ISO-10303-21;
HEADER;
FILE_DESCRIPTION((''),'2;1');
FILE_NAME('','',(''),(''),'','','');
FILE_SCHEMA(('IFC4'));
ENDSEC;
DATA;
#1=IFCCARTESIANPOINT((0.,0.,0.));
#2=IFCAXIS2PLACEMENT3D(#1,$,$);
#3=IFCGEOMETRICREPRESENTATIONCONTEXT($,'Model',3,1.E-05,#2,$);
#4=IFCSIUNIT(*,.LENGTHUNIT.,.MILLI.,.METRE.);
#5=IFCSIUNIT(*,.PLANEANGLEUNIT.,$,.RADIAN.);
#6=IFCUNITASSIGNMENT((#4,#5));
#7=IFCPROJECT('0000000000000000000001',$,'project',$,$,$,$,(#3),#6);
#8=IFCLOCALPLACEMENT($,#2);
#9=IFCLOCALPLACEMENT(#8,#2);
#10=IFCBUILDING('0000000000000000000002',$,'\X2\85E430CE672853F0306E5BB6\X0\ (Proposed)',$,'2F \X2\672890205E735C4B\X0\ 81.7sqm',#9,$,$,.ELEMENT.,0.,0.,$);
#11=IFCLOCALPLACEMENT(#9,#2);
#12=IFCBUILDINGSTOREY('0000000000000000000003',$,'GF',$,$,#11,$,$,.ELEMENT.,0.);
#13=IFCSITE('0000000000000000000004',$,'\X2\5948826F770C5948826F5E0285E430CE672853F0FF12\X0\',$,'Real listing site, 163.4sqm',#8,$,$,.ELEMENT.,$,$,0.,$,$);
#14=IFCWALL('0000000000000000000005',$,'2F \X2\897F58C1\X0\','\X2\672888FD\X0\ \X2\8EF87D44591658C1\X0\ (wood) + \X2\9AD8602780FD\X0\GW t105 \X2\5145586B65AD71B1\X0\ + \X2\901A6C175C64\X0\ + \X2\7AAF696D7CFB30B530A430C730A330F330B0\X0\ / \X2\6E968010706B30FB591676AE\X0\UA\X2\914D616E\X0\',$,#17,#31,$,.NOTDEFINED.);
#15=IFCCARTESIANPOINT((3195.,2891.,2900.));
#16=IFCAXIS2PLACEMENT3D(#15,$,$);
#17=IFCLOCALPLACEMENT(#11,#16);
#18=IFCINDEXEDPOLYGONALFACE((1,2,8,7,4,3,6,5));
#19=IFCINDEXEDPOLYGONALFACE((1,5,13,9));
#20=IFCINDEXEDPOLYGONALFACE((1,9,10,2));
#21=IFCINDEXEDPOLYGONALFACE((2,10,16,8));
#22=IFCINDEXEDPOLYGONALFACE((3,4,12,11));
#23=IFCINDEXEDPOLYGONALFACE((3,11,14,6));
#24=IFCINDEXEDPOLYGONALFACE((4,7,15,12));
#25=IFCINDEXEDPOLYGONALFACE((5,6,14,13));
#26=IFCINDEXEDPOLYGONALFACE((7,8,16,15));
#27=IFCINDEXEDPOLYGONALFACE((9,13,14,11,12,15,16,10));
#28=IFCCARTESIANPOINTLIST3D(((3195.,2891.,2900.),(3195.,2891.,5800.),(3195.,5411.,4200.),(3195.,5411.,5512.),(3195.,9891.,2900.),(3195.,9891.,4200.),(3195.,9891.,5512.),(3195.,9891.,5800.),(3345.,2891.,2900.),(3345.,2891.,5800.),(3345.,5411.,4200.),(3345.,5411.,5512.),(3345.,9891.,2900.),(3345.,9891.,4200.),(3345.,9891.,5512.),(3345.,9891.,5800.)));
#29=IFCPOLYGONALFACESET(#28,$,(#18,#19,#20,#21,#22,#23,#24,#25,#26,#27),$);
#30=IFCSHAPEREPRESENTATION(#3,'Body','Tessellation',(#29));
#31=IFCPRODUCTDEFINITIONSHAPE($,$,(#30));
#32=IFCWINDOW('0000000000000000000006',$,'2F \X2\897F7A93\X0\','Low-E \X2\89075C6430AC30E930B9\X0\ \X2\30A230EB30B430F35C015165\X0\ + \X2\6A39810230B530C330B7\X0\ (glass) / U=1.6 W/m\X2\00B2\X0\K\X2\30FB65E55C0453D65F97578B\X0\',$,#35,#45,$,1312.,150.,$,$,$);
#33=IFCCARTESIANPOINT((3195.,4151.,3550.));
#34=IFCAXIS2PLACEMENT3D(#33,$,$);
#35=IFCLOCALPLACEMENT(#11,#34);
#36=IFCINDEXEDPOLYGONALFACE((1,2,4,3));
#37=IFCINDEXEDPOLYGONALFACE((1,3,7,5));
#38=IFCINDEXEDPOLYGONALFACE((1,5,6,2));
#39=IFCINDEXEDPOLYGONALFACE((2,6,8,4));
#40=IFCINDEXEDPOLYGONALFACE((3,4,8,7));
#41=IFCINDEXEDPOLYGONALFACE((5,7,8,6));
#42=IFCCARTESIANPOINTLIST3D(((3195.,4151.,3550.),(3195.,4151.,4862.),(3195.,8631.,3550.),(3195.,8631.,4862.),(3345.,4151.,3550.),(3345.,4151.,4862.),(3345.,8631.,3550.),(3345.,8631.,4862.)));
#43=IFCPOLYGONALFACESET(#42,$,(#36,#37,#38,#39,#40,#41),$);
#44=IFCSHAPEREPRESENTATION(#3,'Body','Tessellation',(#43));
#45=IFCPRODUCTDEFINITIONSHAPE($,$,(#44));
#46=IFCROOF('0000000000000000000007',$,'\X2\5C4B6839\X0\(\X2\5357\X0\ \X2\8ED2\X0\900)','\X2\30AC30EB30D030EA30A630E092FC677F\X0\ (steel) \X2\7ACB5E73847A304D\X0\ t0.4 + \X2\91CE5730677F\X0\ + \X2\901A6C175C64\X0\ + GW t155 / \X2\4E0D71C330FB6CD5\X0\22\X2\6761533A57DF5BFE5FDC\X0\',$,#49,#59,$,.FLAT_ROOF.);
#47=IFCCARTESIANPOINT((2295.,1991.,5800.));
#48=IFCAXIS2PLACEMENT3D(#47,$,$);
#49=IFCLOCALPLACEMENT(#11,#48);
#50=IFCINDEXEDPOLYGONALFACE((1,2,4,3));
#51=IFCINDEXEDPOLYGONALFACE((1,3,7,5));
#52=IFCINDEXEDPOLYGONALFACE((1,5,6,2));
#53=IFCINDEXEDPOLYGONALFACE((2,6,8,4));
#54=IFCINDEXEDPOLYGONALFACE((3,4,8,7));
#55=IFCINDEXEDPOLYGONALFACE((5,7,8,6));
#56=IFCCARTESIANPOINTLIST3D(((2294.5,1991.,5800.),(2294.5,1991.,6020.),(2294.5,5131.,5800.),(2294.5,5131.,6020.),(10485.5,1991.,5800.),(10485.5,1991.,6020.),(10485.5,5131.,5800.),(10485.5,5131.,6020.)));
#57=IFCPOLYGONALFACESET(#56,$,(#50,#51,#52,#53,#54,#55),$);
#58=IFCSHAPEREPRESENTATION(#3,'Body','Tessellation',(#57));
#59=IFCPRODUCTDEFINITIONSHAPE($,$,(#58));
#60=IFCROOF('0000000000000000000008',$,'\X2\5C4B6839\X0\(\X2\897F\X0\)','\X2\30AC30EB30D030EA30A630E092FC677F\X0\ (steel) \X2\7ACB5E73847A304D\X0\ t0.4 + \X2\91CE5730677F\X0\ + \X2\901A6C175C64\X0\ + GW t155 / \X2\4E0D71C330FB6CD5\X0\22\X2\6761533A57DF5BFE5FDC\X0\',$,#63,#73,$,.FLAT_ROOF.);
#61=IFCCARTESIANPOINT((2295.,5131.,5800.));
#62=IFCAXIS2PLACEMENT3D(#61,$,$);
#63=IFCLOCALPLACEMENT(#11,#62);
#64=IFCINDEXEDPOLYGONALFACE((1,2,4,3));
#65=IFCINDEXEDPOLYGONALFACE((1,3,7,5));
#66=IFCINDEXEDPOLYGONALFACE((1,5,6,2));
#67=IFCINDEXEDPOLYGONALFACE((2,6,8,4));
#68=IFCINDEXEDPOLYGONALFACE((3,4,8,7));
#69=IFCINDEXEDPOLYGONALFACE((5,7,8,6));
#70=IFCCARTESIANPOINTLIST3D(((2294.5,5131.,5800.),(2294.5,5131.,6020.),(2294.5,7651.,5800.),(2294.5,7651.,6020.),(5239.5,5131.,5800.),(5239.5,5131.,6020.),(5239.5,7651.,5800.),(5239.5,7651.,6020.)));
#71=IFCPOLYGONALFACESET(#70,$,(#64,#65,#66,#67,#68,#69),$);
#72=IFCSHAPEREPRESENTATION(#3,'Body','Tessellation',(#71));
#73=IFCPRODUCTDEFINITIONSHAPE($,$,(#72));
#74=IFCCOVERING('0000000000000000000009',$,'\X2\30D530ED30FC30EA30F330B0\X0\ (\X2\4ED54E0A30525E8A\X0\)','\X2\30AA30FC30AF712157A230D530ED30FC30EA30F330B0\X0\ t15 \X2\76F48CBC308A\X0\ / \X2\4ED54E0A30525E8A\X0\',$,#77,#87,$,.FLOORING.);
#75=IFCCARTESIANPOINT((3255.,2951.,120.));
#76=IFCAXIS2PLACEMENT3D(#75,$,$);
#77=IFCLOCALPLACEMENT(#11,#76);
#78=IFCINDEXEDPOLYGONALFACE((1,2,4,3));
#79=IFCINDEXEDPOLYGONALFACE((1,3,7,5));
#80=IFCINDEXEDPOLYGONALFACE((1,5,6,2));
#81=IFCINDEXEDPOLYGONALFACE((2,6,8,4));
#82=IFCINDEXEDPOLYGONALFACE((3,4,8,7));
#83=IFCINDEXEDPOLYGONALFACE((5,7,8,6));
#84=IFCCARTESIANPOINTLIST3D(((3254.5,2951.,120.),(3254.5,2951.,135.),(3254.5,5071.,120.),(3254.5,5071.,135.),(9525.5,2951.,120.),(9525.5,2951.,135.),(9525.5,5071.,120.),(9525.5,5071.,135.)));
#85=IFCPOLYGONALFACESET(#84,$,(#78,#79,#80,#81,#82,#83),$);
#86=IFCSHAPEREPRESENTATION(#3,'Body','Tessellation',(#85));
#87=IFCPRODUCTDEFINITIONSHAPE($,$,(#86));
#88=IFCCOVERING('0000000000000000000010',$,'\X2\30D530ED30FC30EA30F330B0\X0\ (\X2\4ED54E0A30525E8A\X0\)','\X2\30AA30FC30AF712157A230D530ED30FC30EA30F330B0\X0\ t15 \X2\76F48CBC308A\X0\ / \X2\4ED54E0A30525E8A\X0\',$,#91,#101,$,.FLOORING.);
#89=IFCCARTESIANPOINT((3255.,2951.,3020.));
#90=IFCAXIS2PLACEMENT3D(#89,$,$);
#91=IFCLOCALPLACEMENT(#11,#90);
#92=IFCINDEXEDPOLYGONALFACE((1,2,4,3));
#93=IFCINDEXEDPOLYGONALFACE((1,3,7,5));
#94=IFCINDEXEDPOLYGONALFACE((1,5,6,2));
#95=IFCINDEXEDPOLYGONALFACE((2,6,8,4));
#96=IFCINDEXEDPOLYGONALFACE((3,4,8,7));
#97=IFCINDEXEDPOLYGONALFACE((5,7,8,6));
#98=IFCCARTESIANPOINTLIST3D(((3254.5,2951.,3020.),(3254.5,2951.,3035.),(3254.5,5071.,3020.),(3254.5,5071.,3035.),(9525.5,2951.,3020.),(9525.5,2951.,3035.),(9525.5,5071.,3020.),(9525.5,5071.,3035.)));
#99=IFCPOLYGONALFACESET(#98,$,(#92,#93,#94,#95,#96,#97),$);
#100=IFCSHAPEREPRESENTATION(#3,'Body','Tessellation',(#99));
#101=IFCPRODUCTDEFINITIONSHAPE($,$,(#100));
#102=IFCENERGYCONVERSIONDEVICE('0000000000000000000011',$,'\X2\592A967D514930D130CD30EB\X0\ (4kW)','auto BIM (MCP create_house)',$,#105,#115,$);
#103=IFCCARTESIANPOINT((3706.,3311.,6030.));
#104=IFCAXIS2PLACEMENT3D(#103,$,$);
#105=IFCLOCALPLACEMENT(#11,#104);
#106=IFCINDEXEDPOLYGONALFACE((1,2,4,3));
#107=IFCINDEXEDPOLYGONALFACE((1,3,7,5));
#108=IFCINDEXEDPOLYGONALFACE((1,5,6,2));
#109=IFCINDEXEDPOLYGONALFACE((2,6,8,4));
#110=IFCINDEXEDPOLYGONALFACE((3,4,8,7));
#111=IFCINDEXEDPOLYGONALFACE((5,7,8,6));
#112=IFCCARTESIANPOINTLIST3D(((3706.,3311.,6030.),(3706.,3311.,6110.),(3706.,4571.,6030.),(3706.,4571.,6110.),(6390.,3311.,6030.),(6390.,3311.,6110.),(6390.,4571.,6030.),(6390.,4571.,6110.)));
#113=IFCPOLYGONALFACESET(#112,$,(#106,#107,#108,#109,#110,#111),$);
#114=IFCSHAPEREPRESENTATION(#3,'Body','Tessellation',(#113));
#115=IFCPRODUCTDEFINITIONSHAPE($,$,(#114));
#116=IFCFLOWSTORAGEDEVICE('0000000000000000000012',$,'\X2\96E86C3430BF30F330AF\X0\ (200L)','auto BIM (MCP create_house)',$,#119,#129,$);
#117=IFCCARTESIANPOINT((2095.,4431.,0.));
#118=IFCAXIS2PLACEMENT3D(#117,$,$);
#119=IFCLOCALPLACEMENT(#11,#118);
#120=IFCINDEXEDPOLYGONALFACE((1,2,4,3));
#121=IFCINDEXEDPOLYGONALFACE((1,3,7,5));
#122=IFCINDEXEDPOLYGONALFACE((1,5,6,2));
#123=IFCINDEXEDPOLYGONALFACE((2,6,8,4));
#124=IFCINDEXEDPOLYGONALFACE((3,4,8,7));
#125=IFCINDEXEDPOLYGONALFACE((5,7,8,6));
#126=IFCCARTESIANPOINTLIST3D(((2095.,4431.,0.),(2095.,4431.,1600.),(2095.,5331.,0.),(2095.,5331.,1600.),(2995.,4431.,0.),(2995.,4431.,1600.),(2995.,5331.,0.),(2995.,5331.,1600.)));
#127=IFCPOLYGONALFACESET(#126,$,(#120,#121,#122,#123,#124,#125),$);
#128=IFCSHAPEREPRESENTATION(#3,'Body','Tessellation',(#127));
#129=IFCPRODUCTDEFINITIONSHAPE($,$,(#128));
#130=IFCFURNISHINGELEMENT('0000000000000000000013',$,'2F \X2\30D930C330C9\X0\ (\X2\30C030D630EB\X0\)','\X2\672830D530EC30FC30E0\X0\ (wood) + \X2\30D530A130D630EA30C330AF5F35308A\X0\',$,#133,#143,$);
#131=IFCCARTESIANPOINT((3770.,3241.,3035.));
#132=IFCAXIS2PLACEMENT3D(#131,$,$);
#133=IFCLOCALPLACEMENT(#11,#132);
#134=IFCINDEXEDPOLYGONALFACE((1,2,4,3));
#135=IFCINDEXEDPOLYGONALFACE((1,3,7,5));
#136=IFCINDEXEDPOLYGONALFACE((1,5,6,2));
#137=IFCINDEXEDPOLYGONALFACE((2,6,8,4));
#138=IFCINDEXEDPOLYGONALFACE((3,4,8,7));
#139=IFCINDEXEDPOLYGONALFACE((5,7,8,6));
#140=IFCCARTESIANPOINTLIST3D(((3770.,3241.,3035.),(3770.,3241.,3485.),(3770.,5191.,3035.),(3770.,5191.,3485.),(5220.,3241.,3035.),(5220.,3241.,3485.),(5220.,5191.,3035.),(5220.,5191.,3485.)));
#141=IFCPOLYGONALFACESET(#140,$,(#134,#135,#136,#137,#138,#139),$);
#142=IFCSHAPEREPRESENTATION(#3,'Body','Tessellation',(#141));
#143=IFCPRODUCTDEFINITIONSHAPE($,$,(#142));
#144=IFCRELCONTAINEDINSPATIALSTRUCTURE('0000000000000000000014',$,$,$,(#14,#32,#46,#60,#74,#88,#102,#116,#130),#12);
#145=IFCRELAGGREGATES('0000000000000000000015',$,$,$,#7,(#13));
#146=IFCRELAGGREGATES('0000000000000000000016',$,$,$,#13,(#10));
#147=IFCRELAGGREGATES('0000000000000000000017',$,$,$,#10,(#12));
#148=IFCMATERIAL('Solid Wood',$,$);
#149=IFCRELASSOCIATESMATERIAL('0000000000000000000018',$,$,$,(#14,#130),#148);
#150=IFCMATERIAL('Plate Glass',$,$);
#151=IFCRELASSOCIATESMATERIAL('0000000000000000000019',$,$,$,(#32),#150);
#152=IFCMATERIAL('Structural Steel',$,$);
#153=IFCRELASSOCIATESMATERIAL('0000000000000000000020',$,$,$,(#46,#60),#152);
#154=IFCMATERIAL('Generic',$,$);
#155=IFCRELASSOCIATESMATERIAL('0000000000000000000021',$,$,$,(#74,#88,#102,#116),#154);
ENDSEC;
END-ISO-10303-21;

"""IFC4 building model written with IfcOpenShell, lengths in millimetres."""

from ifc_helpers import new_model, si_unit, frame, frame_2d, origin, place, context, project, spatial, rectangle, extrude, material, element, fill, save


model = new_model("IFC4")

# Units and contexts
model_context = context("Model", 3, precision=1e-05, world=origin())
ifc_project = project(units=[si_unit("LENGTHUNIT", "METRE", prefix="MILLI"), si_unit("PLANEANGLEUNIT", "RADIAN")], contexts=[model_context])

# Site, building, storey
site_placement = place(None, origin())
site = spatial("IfcSite", under=ifc_project, at=site_placement, Name="奈良県奈良市藤ノ木台２", ObjectType="Real listing site, 163.4sqm", CompositionType="ELEMENT", RefElevation=0.0)
building_placement = place(site_placement, origin())
building = spatial("IfcBuilding", under=site, at=building_placement, Name="藤ノ木台の家 (Proposed)", ObjectType="2F 木造平屋 81.7sqm", CompositionType="ELEMENT", ElevationOfRefHeight=0.0, ElevationOfTerrain=0.0)
storey_placement = place(building_placement, origin())
storey = spatial("IfcBuildingStorey", under=building, at=storey_placement, Name="GF", CompositionType="ELEMENT", Elevation=0.0)

# Shared definitions
ifc_material_1 = material(Name="Solid Wood")

# Shared definitions
ifc_material_2 = material(Name="Plate Glass")

# Wall, opening, window
wall_1_placement = place(storey_placement, frame((3195.0, 2891.0, 2900.0)))
wall_1 = element("IfcWall", 1, at=wall_1_placement, inside=storey, material=ifc_material_1, Name="2F 西壁", Description="木製 軸組外壁 (wood) + 高性能GW t105 充填断熱 + 通気層 + 窯業系サイディング / 準耐火・外皮UA配慮", PredefinedType="NOTDEFINED", context=model_context, shape_type="SweptSolid", body=[
    extrude(rectangle(XDim=150.0, YDim=7000.0, at=frame_2d((75.0, 3500.0))), frame((3195.0, 2891.0, 2900.0)), (0.0, 0.0, 1.0), 2900.0),
])
opening_1_placement = place(storey_placement, frame((3195.0, 4151.0, 3550.0)))
opening_1 = element("IfcOpeningElement", 2, at=opening_1_placement, cuts=wall_1, PredefinedType="NOTDEFINED", context=model_context, shape_type="SweptSolid", body=[
    extrude(rectangle(XDim=150.0, YDim=4480.0, at=frame_2d((75.0, 2240.0))), frame((3195.0, 4151.0, 3550.0)), (0.0, 0.0, 1.0), 1312.0),
])
window_1_placement = place(storey_placement, frame((3195.0, 4151.0, 3550.0)))
window_1 = element("IfcWindow", 3, at=window_1_placement, inside=storey, material=ifc_material_2, Name="2F 西窓", Description="Low-E 複層ガラス アルゴン封入 + 樹脂サッシ (glass) / U=1.6 W/m²K・日射取得型", OverallHeight=1312.0, OverallWidth=150.0, context=model_context, shape_type="SweptSolid", body=[
    extrude(rectangle(XDim=150.0, YDim=4480.0, at=frame_2d((75.0, 2240.0))), frame((3195.0, 4151.0, 3550.0)), (0.0, 0.0, 1.0), 1312.0),
])
fill(opening_1, window_1)

# Roofs
ifc_material_3 = material(Name="Structural Steel")
roof_1_placement = place(storey_placement, frame((2295.0, 1991.0, 5800.0)))
element("IfcRoof", 4, at=roof_1_placement, inside=storey, material=ifc_material_3, Name="屋根(南 軒900)", Description="ガルバリウム鋼板 (steel) 立平葺き t0.4 + 野地板 + 通気層 + GW t155 / 不燃・法22条区域対応", PredefinedType="FLAT_ROOF", context=model_context, shape_type="SweptSolid", body=[
    extrude(rectangle(XDim=8191.0, YDim=3140.0, at=frame_2d((4095.0, 1570.0))), frame((2295.0, 1991.0, 5800.0)), (0.0, 0.0, 1.0), 220.0),
])
roof_2_placement = place(storey_placement, frame((2295.0, 5131.0, 5800.0)))
element("IfcRoof", 5, at=roof_2_placement, inside=storey, material=ifc_material_3, Name="屋根(西)", Description="ガルバリウム鋼板 (steel) 立平葺き t0.4 + 野地板 + 通気層 + GW t155 / 不燃・法22条区域対応", PredefinedType="FLAT_ROOF", context=model_context, shape_type="SweptSolid", body=[
    extrude(rectangle(XDim=2945.0, YDim=2520.0, at=frame_2d((1472.0, 1260.0))), frame((2295.0, 5131.0, 5800.0)), (0.0, 0.0, 1.0), 220.0),
])

# Coverings
ifc_material_4 = material(Name="Generic")
covering_1_placement = place(storey_placement, frame((3255.0, 2951.0, 120.0)))
element("IfcCovering", 6, at=covering_1_placement, inside=storey, material=ifc_material_4, Name="フローリング (仕上げ床)", Description="オーク無垢フローリング t15 直貼り / 仕上げ床", PredefinedType="FLOORING", context=model_context, shape_type="SweptSolid", body=[
    extrude(rectangle(XDim=6271.0, YDim=2120.0, at=frame_2d((3135.0, 1060.0))), frame((3255.0, 2951.0, 120.0)), (0.0, 0.0, 1.0), 15.0),
])
covering_2_placement = place(storey_placement, frame((3255.0, 2951.0, 3020.0)))
element("IfcCovering", 7, at=covering_2_placement, inside=storey, material=ifc_material_4, Name="フローリング (仕上げ床)", Description="オーク無垢フローリング t15 直貼り / 仕上げ床", PredefinedType="FLOORING", context=model_context, shape_type="SweptSolid", body=[
    extrude(rectangle(XDim=6271.0, YDim=2120.0, at=frame_2d((3135.0, 1060.0))), frame((3255.0, 2951.0, 3020.0)), (0.0, 0.0, 1.0), 15.0),
])

# Energy conversion device
energy_conversion_device_placement = place(storey_placement, frame((3706.0, 3311.0, 6030.0)))
element("IfcEnergyConversionDevice", 8, at=energy_conversion_device_placement, inside=storey, material=ifc_material_4, Name="太陽光パネル (4kW)", Description="auto BIM (MCP create_house)", context=model_context, shape_type="SweptSolid", body=[
    extrude(rectangle(XDim=2684.0, YDim=1260.0, at=frame_2d((1342.0, 630.0))), frame((3706.0, 3311.0, 6030.0)), (0.0, 0.0, 1.0), 80.0),
])

# Flow storage device
flow_storage_device_placement = place(storey_placement, frame((2095.0, 4431.0, 0.0)))
element("IfcFlowStorageDevice", 9, at=flow_storage_device_placement, inside=storey, material=ifc_material_4, Name="雨水タンク (200L)", Description="auto BIM (MCP create_house)", context=model_context, shape_type="SweptSolid", body=[
    extrude(rectangle(XDim=900.0, YDim=900.0, at=frame_2d((450.0, 450.0))), frame((2095.0, 4431.0, 0.0)), (0.0, 0.0, 1.0), 1600.0),
])

# Furnishing element
furnishing_placement = place(storey_placement, frame((3770.0, 3241.0, 3035.0)))
element("IfcFurnishingElement", 10, at=furnishing_placement, inside=storey, material=ifc_material_1, Name="2F ベッド (ダブル)", Description="木フレーム (wood) + ファブリック張り", context=model_context, shape_type="SweptSolid", body=[
    extrude(rectangle(XDim=1450.0, YDim=1950.0, at=frame_2d((725.0, 975.0))), frame((3770.0, 3241.0, 3035.0)), (0.0, 0.0, 1.0), 450.0),
])

save(model, "model.ifc")
